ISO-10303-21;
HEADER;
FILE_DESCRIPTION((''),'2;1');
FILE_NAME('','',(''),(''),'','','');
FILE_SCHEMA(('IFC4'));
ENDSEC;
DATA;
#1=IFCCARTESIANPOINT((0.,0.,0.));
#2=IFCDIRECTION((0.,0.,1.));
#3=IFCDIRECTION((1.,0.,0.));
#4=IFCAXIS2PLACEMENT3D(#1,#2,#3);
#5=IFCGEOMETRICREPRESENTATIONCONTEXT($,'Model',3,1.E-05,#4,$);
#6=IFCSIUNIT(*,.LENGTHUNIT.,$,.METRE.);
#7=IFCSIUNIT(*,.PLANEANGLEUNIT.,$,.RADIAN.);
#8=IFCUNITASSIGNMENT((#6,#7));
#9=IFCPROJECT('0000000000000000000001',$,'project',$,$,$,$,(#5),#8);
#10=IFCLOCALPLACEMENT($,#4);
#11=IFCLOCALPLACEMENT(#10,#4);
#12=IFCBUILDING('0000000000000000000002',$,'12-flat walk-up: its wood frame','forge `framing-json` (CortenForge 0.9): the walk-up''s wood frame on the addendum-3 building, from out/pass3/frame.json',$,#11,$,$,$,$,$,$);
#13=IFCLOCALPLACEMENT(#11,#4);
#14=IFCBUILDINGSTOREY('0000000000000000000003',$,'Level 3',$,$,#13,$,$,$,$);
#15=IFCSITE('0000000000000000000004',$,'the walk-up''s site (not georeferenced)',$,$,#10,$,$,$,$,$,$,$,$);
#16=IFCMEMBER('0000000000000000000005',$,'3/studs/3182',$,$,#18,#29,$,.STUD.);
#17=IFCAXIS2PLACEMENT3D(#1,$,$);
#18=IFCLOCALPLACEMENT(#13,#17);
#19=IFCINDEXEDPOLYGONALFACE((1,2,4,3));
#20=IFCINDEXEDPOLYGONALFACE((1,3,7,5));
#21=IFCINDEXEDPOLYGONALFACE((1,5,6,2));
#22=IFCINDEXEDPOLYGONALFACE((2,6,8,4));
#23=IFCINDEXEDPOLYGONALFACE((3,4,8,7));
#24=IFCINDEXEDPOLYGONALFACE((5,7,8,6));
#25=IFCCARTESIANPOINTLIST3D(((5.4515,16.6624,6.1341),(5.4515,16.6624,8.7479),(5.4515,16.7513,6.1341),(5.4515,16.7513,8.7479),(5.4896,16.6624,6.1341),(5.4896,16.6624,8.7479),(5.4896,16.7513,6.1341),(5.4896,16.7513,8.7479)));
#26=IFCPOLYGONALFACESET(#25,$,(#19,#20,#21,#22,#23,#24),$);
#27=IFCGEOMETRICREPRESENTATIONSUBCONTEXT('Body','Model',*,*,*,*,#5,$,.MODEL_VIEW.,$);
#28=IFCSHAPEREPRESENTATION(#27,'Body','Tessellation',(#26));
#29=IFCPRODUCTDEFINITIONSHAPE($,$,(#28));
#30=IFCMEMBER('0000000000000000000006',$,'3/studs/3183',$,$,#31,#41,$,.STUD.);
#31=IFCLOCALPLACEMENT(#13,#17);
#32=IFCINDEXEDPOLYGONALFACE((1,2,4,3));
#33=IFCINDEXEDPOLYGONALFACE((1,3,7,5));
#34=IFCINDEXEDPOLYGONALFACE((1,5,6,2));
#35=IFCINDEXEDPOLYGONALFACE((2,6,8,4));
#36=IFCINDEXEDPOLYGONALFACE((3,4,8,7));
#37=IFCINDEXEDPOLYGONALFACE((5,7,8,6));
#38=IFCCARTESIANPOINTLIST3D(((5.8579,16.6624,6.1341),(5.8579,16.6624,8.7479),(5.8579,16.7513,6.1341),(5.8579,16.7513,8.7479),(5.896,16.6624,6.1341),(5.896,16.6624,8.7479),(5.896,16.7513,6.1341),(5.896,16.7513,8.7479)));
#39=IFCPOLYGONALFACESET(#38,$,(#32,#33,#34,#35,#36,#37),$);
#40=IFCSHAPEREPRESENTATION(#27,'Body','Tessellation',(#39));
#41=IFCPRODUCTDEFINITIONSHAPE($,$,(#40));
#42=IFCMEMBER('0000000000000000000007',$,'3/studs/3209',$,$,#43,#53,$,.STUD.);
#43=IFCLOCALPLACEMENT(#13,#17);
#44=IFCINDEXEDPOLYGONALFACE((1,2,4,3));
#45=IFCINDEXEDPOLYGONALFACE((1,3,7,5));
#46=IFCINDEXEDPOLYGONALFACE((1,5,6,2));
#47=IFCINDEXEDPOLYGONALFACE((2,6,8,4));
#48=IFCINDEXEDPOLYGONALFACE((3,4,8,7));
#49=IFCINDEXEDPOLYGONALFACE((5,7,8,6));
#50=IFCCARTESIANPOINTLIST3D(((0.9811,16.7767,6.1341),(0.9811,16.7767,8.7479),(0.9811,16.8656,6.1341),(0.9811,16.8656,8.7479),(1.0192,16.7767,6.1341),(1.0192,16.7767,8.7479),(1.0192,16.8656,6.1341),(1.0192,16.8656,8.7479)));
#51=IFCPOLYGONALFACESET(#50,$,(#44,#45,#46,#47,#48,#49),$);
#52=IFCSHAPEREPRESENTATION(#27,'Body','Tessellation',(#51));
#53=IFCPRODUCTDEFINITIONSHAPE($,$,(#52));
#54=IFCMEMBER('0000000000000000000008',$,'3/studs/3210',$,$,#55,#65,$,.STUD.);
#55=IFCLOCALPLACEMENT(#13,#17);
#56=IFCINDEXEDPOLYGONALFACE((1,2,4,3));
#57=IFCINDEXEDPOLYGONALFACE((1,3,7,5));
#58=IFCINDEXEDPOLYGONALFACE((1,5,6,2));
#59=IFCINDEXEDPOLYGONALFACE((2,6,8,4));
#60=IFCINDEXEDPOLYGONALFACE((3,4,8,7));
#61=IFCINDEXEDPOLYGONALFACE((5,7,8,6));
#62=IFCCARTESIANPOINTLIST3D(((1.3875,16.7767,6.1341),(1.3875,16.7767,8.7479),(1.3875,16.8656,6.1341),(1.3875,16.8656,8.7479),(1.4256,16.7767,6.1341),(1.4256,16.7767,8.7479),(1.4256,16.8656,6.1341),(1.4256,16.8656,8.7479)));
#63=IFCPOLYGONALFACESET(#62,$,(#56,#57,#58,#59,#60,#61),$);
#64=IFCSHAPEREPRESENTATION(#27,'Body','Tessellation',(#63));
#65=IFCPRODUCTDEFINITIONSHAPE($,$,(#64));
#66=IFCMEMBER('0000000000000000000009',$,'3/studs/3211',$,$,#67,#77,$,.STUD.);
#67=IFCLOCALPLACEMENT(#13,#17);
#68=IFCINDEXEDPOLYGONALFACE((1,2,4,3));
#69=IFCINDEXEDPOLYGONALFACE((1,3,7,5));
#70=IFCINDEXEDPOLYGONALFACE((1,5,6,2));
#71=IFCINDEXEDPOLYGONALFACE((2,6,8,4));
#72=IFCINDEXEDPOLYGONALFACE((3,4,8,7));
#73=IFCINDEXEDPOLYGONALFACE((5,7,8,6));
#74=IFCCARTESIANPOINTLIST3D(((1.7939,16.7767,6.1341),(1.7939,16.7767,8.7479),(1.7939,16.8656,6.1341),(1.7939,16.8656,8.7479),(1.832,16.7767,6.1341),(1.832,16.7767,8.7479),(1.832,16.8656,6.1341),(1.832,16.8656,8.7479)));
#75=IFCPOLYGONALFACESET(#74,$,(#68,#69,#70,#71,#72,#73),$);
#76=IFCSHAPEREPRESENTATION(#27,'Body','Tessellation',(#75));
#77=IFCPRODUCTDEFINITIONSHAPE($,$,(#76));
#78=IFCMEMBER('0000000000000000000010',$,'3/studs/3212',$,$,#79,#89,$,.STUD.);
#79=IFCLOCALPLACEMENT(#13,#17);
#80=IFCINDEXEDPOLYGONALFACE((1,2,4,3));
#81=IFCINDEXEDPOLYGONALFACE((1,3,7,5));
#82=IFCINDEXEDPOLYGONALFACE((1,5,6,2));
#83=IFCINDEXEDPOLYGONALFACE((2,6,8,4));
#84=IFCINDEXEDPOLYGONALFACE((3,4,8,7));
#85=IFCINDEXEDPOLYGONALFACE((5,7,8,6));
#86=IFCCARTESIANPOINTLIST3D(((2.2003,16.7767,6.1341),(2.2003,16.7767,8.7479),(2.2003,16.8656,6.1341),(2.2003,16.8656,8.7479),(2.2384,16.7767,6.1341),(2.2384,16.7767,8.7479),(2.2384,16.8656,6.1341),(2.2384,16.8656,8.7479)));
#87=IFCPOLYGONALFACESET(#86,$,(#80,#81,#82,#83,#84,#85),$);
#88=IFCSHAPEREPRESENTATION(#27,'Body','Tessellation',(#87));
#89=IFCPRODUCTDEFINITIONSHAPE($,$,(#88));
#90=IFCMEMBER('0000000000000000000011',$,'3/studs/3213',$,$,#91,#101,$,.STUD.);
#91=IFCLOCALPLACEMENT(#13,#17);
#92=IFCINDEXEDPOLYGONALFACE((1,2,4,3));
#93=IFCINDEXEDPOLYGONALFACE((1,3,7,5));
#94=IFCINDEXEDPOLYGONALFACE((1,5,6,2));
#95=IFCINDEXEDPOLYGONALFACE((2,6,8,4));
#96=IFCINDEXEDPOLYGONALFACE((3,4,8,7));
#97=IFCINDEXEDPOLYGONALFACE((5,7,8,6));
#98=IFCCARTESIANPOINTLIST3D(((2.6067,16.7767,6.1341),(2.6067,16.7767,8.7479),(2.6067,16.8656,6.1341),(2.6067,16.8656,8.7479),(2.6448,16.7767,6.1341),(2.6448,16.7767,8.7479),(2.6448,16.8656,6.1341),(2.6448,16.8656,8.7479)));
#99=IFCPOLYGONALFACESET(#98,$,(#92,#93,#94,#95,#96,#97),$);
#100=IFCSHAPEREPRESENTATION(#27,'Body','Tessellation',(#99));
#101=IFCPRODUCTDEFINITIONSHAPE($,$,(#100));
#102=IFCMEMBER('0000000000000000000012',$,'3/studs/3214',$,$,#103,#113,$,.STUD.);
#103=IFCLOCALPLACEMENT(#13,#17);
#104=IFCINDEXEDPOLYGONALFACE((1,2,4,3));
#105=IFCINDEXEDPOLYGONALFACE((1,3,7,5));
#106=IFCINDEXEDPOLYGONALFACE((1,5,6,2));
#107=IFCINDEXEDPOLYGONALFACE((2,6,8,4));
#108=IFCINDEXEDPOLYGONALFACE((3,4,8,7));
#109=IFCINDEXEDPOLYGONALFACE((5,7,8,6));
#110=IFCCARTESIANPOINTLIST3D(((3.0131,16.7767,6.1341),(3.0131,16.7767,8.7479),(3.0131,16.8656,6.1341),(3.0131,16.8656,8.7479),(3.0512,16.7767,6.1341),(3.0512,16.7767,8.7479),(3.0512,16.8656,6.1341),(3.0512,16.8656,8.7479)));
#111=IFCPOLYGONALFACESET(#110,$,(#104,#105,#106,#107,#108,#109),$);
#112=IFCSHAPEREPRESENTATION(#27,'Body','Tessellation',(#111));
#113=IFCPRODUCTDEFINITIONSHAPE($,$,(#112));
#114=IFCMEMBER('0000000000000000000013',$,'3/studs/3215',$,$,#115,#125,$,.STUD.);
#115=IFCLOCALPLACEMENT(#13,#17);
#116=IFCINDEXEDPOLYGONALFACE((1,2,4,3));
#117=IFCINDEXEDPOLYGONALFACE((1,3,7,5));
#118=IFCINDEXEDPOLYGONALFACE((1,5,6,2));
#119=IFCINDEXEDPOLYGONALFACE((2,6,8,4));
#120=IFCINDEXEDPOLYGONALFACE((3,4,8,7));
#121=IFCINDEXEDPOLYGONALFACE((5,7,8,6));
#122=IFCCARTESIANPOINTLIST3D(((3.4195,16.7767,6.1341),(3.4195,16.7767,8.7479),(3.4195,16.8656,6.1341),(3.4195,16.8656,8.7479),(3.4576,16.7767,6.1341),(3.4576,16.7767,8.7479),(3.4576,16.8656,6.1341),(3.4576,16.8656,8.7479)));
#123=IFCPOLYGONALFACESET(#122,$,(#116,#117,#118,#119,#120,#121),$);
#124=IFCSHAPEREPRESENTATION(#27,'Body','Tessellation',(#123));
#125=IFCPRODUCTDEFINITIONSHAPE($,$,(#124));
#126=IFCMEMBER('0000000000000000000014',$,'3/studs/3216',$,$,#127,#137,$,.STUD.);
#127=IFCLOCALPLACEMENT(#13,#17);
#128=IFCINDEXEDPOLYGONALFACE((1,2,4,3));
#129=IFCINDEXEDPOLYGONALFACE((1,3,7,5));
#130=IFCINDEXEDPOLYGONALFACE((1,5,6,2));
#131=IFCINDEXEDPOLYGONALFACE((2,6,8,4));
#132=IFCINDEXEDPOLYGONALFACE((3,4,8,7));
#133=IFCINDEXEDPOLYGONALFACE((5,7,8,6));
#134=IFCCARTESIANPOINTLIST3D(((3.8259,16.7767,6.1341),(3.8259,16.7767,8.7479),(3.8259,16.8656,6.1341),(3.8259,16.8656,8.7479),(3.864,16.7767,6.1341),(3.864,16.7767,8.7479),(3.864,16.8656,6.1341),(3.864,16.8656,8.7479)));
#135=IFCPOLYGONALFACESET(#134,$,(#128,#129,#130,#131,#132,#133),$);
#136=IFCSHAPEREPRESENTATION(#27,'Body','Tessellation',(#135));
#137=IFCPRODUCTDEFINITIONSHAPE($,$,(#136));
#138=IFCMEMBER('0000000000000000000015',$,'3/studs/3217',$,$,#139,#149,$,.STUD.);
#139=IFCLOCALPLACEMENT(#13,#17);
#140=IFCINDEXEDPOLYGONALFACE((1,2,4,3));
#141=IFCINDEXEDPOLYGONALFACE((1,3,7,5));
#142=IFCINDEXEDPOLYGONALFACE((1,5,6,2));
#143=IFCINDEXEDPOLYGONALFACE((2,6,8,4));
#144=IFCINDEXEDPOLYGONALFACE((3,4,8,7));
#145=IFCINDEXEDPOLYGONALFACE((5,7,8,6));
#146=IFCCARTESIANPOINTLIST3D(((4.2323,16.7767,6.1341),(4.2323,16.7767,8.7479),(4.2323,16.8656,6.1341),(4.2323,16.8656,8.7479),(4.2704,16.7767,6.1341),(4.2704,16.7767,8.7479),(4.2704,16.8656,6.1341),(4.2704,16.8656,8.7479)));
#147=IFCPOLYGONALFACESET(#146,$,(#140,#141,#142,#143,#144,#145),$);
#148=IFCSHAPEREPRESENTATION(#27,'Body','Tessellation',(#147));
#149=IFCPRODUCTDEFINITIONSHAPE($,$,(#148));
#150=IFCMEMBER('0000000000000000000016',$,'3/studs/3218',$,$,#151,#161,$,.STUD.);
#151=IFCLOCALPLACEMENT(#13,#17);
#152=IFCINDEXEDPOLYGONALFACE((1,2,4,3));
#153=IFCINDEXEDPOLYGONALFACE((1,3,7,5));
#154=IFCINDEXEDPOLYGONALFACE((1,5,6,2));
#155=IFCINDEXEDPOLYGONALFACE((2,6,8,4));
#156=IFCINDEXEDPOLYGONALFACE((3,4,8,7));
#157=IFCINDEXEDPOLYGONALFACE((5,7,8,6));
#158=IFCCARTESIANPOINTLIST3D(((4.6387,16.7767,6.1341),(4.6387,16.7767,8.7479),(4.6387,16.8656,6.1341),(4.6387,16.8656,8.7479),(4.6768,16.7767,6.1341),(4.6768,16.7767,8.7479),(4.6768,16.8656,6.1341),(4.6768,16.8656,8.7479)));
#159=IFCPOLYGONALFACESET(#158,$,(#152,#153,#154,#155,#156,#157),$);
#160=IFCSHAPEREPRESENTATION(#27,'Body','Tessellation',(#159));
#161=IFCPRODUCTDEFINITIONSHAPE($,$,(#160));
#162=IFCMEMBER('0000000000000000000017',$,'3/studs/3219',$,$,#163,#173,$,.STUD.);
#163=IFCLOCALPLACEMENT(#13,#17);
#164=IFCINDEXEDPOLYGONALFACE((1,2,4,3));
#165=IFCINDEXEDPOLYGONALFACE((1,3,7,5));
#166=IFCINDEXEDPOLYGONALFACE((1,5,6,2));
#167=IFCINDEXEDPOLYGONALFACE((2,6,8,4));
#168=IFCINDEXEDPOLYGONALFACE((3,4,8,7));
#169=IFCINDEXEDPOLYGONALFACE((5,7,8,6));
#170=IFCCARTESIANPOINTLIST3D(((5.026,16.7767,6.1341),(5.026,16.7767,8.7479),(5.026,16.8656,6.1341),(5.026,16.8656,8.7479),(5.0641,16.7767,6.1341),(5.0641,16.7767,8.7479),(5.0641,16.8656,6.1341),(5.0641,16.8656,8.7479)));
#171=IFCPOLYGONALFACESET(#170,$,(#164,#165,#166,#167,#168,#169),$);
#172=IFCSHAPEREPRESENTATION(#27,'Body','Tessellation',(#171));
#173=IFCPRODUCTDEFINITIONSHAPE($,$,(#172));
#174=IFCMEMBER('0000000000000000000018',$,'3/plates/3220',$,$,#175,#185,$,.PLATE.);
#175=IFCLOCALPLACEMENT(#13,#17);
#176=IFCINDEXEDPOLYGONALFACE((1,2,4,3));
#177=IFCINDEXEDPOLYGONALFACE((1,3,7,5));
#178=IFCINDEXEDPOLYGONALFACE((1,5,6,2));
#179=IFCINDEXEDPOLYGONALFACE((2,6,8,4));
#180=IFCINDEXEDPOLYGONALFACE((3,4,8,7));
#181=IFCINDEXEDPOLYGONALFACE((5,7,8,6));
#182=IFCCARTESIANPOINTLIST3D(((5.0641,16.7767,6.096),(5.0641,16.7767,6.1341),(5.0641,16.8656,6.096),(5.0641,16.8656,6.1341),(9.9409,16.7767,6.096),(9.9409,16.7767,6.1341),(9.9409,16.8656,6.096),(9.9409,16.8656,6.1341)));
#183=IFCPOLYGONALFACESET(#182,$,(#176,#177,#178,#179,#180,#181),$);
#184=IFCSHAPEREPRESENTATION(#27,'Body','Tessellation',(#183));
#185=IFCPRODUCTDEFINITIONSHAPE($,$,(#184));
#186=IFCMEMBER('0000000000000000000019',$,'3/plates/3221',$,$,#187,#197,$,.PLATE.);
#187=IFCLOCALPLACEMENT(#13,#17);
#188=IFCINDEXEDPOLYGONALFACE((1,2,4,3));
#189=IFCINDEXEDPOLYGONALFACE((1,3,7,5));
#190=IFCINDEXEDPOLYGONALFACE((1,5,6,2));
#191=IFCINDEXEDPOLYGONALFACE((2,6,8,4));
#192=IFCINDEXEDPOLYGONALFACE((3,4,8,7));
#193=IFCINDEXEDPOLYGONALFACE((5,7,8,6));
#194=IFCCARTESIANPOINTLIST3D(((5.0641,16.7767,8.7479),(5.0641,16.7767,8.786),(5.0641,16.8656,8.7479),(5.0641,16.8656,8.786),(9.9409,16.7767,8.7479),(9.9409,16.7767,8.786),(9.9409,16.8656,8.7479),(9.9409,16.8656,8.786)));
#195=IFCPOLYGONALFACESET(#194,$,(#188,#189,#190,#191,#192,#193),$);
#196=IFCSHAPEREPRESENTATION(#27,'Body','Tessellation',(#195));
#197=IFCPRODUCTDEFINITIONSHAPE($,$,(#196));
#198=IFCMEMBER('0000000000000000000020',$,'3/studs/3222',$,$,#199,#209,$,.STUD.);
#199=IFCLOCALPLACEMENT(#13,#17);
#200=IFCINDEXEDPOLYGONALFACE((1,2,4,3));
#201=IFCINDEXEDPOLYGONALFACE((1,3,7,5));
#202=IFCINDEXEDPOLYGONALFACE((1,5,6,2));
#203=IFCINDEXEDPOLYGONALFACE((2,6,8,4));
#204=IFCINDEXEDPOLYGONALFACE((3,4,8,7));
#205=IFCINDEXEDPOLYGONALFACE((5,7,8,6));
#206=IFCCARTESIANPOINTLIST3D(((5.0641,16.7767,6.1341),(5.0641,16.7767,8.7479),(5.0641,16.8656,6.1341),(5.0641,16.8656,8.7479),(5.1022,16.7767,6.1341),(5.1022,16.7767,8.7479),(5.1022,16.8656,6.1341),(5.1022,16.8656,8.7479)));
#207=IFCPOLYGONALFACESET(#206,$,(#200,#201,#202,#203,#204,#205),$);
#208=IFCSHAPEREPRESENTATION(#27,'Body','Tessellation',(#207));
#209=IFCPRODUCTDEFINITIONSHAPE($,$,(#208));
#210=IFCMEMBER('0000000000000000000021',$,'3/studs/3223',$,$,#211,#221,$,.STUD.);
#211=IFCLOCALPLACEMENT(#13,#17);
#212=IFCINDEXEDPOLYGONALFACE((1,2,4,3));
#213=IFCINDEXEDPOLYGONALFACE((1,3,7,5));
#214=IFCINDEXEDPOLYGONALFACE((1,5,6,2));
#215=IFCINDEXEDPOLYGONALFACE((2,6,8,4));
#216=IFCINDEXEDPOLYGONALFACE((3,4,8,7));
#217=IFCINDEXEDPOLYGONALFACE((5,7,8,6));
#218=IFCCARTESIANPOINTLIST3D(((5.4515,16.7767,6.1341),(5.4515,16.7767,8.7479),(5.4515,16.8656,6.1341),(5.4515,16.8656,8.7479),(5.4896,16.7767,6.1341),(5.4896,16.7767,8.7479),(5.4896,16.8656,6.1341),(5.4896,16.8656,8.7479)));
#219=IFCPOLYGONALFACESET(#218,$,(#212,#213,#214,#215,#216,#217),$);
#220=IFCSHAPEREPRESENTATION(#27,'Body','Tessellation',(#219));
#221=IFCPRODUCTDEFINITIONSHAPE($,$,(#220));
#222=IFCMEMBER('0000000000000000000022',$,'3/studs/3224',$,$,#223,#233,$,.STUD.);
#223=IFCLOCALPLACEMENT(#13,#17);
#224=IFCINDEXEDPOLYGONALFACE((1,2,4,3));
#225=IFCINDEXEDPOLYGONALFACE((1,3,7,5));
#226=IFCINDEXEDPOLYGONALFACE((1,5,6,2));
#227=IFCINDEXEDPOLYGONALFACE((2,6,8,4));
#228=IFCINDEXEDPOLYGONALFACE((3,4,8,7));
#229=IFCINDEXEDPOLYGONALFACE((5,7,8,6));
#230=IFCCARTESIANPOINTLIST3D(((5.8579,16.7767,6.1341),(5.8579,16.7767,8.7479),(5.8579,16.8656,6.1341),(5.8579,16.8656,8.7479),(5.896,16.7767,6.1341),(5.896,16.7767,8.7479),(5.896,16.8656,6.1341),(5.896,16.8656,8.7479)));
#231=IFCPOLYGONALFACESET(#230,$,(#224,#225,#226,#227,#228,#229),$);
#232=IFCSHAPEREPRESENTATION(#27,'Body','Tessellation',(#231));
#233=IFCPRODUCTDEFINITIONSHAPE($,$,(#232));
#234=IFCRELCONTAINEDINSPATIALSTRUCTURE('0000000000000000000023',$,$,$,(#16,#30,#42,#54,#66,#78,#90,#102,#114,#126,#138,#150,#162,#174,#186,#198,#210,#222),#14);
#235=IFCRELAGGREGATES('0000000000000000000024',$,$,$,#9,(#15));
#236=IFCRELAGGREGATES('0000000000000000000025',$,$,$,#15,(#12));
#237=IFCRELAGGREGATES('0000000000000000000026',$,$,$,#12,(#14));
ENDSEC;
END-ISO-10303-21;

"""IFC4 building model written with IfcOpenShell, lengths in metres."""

from ifc_helpers import new_model, si_unit, frame, frame_2d, origin, origin_with_axes, place, context, subcontext, project, spatial, rectangle, extrude, element, save


model = new_model("IFC4")

# Units and contexts
model_context = context("Model", 3, precision=1e-05, world=origin_with_axes())
body_context = subcontext(model_context, "Body", "Model", "MODEL_VIEW")
ifc_project = project(units=[si_unit("LENGTHUNIT", "METRE"), si_unit("PLANEANGLEUNIT", "RADIAN")], contexts=[model_context])

# Site, building, storey
site_placement = place(None, origin_with_axes())
site = spatial("IfcSite", under=ifc_project, at=site_placement, Name="the walk-up's site (not georeferenced)")
building_placement = place(site_placement, origin_with_axes())
building = spatial("IfcBuilding", under=site, at=building_placement, Name="12-flat walk-up: its wood frame", Description="forge `framing-json` (CortenForge 0.9): the walk-up's wood frame on the addendum-3 building, from out/pass3/frame.json")
storey_placement = place(building_placement, origin_with_axes())
storey = spatial("IfcBuildingStorey", under=building, at=storey_placement, Name="Level 3")

# Members
for number, where, z_axis, x_axis, name in (
    (1, (5.4515, 16.6624, 6.1341), (0.0, 0.0, 1.0), (1.0, 0.0, 0.0), "3/studs/3182"),
    (2, (5.8579, 16.6624, 6.1341), (0.0, 0.0, 1.0), (1.0, 0.0, 0.0), "3/studs/3183"),
):
    element("IfcMember", number, at=place(storey_placement, frame(where, z_axis=z_axis, x_axis=x_axis)), inside=storey, Name=name, PredefinedType="STUD", context=body_context, shape_type="SweptSolid", body=[
        extrude(rectangle(XDim=0.0381, YDim=0.0889, at=frame_2d((0.0191, 0.0444))), origin(), (0.0, 0.0, 1.0), 2.6138),
    ])
member_1_placement = place(storey_placement, frame((0.9811, 16.7767, 6.1341), z_axis=(0.0, 0.0, 1.0), x_axis=(1.0, 0.0, 0.0)))
element("IfcMember", 3, at=member_1_placement, inside=storey, Name="3/studs/3209", PredefinedType="STUD", context=body_context, shape_type="SweptSolid", body=[
    extrude(rectangle(XDim=0.0381, YDim=0.0889, at=frame_2d((0.019, 0.0444))), origin(), (0.0, 0.0, 1.0), 2.6138),
])
member_2_placement = place(storey_placement, frame((1.3875, 16.7767, 6.1341), z_axis=(0.0, 0.0, 1.0), x_axis=(1.0, 0.0, 0.0)))
element("IfcMember", 4, at=member_2_placement, inside=storey, Name="3/studs/3210", PredefinedType="STUD", context=body_context, shape_type="SweptSolid", body=[
    extrude(rectangle(XDim=0.0381, YDim=0.0889, at=frame_2d((0.0191, 0.0444))), origin(), (0.0, 0.0, 1.0), 2.6138),
])
member_3_placement = place(storey_placement, frame((1.7939, 16.7767, 6.1341), z_axis=(0.0, 0.0, 1.0), x_axis=(1.0, 0.0, 0.0)))
element("IfcMember", 5, at=member_3_placement, inside=storey, Name="3/studs/3211", PredefinedType="STUD", context=body_context, shape_type="SweptSolid", body=[
    extrude(rectangle(XDim=0.0381, YDim=0.0889, at=frame_2d((0.019, 0.0444))), origin(), (0.0, 0.0, 1.0), 2.6138),
])
for number, where, z_axis, x_axis, name in (
    (6, (2.2003, 16.7767, 6.1341), (0.0, 0.0, 1.0), (1.0, 0.0, 0.0), "3/studs/3212"),
    (7, (2.6067, 16.7767, 6.1341), (0.0, 0.0, 1.0), (1.0, 0.0, 0.0), "3/studs/3213"),
    (8, (3.0131, 16.7767, 6.1341), (0.0, 0.0, 1.0), (1.0, 0.0, 0.0), "3/studs/3214"),
    (9, (3.4195, 16.7767, 6.1341), (0.0, 0.0, 1.0), (1.0, 0.0, 0.0), "3/studs/3215"),
    (10, (3.8259, 16.7767, 6.1341), (0.0, 0.0, 1.0), (1.0, 0.0, 0.0), "3/studs/3216"),
    (11, (4.2323, 16.7767, 6.1341), (0.0, 0.0, 1.0), (1.0, 0.0, 0.0), "3/studs/3217"),
    (12, (4.6387, 16.7767, 6.1341), (0.0, 0.0, 1.0), (1.0, 0.0, 0.0), "3/studs/3218"),
    (13, (5.026, 16.7767, 6.1341), (0.0, 0.0, 1.0), (1.0, 0.0, 0.0), "3/studs/3219"),
):
    element("IfcMember", number, at=place(storey_placement, frame(where, z_axis=z_axis, x_axis=x_axis)), inside=storey, Name=name, PredefinedType="STUD", context=body_context, shape_type="SweptSolid", body=[
        extrude(rectangle(XDim=0.0381, YDim=0.0889, at=frame_2d((0.0191, 0.0444))), origin(), (0.0, 0.0, 1.0), 2.6138),
    ])
for number, where, z_axis, x_axis, name in (
    (14, (5.0641, 16.7767, 6.096), (0.0, 0.0, 1.0), (1.0, 0.0, 0.0), "3/plates/3220"),
    (15, (5.0641, 16.7767, 8.7479), (0.0, 0.0, 1.0), (1.0, 0.0, 0.0), "3/plates/3221"),
):
    element("IfcMember", number, at=place(storey_placement, frame(where, z_axis=z_axis, x_axis=x_axis)), inside=storey, Name=name, PredefinedType="PLATE", context=body_context, shape_type="SweptSolid", body=[
        extrude(rectangle(XDim=4.8768, YDim=0.0889, at=frame_2d((2.4384, 0.0444))), origin(), (0.0, 0.0, 1.0), 0.0381),
    ])
for number, where, z_axis, x_axis, name in (
    (16, (5.0641, 16.7767, 6.1341), (0.0, 0.0, 1.0), (1.0, 0.0, 0.0), "3/studs/3222"),
    (17, (5.4515, 16.7767, 6.1341), (0.0, 0.0, 1.0), (1.0, 0.0, 0.0), "3/studs/3223"),
    (18, (5.8579, 16.7767, 6.1341), (0.0, 0.0, 1.0), (1.0, 0.0, 0.0), "3/studs/3224"),
):
    element("IfcMember", number, at=place(storey_placement, frame(where, z_axis=z_axis, x_axis=x_axis)), inside=storey, Name=name, PredefinedType="STUD", context=body_context, shape_type="SweptSolid", body=[
        extrude(rectangle(XDim=0.0381, YDim=0.0889, at=frame_2d((0.0191, 0.0444))), origin(), (0.0, 0.0, 1.0), 2.6138),
    ])

save(model, "model.ifc")
